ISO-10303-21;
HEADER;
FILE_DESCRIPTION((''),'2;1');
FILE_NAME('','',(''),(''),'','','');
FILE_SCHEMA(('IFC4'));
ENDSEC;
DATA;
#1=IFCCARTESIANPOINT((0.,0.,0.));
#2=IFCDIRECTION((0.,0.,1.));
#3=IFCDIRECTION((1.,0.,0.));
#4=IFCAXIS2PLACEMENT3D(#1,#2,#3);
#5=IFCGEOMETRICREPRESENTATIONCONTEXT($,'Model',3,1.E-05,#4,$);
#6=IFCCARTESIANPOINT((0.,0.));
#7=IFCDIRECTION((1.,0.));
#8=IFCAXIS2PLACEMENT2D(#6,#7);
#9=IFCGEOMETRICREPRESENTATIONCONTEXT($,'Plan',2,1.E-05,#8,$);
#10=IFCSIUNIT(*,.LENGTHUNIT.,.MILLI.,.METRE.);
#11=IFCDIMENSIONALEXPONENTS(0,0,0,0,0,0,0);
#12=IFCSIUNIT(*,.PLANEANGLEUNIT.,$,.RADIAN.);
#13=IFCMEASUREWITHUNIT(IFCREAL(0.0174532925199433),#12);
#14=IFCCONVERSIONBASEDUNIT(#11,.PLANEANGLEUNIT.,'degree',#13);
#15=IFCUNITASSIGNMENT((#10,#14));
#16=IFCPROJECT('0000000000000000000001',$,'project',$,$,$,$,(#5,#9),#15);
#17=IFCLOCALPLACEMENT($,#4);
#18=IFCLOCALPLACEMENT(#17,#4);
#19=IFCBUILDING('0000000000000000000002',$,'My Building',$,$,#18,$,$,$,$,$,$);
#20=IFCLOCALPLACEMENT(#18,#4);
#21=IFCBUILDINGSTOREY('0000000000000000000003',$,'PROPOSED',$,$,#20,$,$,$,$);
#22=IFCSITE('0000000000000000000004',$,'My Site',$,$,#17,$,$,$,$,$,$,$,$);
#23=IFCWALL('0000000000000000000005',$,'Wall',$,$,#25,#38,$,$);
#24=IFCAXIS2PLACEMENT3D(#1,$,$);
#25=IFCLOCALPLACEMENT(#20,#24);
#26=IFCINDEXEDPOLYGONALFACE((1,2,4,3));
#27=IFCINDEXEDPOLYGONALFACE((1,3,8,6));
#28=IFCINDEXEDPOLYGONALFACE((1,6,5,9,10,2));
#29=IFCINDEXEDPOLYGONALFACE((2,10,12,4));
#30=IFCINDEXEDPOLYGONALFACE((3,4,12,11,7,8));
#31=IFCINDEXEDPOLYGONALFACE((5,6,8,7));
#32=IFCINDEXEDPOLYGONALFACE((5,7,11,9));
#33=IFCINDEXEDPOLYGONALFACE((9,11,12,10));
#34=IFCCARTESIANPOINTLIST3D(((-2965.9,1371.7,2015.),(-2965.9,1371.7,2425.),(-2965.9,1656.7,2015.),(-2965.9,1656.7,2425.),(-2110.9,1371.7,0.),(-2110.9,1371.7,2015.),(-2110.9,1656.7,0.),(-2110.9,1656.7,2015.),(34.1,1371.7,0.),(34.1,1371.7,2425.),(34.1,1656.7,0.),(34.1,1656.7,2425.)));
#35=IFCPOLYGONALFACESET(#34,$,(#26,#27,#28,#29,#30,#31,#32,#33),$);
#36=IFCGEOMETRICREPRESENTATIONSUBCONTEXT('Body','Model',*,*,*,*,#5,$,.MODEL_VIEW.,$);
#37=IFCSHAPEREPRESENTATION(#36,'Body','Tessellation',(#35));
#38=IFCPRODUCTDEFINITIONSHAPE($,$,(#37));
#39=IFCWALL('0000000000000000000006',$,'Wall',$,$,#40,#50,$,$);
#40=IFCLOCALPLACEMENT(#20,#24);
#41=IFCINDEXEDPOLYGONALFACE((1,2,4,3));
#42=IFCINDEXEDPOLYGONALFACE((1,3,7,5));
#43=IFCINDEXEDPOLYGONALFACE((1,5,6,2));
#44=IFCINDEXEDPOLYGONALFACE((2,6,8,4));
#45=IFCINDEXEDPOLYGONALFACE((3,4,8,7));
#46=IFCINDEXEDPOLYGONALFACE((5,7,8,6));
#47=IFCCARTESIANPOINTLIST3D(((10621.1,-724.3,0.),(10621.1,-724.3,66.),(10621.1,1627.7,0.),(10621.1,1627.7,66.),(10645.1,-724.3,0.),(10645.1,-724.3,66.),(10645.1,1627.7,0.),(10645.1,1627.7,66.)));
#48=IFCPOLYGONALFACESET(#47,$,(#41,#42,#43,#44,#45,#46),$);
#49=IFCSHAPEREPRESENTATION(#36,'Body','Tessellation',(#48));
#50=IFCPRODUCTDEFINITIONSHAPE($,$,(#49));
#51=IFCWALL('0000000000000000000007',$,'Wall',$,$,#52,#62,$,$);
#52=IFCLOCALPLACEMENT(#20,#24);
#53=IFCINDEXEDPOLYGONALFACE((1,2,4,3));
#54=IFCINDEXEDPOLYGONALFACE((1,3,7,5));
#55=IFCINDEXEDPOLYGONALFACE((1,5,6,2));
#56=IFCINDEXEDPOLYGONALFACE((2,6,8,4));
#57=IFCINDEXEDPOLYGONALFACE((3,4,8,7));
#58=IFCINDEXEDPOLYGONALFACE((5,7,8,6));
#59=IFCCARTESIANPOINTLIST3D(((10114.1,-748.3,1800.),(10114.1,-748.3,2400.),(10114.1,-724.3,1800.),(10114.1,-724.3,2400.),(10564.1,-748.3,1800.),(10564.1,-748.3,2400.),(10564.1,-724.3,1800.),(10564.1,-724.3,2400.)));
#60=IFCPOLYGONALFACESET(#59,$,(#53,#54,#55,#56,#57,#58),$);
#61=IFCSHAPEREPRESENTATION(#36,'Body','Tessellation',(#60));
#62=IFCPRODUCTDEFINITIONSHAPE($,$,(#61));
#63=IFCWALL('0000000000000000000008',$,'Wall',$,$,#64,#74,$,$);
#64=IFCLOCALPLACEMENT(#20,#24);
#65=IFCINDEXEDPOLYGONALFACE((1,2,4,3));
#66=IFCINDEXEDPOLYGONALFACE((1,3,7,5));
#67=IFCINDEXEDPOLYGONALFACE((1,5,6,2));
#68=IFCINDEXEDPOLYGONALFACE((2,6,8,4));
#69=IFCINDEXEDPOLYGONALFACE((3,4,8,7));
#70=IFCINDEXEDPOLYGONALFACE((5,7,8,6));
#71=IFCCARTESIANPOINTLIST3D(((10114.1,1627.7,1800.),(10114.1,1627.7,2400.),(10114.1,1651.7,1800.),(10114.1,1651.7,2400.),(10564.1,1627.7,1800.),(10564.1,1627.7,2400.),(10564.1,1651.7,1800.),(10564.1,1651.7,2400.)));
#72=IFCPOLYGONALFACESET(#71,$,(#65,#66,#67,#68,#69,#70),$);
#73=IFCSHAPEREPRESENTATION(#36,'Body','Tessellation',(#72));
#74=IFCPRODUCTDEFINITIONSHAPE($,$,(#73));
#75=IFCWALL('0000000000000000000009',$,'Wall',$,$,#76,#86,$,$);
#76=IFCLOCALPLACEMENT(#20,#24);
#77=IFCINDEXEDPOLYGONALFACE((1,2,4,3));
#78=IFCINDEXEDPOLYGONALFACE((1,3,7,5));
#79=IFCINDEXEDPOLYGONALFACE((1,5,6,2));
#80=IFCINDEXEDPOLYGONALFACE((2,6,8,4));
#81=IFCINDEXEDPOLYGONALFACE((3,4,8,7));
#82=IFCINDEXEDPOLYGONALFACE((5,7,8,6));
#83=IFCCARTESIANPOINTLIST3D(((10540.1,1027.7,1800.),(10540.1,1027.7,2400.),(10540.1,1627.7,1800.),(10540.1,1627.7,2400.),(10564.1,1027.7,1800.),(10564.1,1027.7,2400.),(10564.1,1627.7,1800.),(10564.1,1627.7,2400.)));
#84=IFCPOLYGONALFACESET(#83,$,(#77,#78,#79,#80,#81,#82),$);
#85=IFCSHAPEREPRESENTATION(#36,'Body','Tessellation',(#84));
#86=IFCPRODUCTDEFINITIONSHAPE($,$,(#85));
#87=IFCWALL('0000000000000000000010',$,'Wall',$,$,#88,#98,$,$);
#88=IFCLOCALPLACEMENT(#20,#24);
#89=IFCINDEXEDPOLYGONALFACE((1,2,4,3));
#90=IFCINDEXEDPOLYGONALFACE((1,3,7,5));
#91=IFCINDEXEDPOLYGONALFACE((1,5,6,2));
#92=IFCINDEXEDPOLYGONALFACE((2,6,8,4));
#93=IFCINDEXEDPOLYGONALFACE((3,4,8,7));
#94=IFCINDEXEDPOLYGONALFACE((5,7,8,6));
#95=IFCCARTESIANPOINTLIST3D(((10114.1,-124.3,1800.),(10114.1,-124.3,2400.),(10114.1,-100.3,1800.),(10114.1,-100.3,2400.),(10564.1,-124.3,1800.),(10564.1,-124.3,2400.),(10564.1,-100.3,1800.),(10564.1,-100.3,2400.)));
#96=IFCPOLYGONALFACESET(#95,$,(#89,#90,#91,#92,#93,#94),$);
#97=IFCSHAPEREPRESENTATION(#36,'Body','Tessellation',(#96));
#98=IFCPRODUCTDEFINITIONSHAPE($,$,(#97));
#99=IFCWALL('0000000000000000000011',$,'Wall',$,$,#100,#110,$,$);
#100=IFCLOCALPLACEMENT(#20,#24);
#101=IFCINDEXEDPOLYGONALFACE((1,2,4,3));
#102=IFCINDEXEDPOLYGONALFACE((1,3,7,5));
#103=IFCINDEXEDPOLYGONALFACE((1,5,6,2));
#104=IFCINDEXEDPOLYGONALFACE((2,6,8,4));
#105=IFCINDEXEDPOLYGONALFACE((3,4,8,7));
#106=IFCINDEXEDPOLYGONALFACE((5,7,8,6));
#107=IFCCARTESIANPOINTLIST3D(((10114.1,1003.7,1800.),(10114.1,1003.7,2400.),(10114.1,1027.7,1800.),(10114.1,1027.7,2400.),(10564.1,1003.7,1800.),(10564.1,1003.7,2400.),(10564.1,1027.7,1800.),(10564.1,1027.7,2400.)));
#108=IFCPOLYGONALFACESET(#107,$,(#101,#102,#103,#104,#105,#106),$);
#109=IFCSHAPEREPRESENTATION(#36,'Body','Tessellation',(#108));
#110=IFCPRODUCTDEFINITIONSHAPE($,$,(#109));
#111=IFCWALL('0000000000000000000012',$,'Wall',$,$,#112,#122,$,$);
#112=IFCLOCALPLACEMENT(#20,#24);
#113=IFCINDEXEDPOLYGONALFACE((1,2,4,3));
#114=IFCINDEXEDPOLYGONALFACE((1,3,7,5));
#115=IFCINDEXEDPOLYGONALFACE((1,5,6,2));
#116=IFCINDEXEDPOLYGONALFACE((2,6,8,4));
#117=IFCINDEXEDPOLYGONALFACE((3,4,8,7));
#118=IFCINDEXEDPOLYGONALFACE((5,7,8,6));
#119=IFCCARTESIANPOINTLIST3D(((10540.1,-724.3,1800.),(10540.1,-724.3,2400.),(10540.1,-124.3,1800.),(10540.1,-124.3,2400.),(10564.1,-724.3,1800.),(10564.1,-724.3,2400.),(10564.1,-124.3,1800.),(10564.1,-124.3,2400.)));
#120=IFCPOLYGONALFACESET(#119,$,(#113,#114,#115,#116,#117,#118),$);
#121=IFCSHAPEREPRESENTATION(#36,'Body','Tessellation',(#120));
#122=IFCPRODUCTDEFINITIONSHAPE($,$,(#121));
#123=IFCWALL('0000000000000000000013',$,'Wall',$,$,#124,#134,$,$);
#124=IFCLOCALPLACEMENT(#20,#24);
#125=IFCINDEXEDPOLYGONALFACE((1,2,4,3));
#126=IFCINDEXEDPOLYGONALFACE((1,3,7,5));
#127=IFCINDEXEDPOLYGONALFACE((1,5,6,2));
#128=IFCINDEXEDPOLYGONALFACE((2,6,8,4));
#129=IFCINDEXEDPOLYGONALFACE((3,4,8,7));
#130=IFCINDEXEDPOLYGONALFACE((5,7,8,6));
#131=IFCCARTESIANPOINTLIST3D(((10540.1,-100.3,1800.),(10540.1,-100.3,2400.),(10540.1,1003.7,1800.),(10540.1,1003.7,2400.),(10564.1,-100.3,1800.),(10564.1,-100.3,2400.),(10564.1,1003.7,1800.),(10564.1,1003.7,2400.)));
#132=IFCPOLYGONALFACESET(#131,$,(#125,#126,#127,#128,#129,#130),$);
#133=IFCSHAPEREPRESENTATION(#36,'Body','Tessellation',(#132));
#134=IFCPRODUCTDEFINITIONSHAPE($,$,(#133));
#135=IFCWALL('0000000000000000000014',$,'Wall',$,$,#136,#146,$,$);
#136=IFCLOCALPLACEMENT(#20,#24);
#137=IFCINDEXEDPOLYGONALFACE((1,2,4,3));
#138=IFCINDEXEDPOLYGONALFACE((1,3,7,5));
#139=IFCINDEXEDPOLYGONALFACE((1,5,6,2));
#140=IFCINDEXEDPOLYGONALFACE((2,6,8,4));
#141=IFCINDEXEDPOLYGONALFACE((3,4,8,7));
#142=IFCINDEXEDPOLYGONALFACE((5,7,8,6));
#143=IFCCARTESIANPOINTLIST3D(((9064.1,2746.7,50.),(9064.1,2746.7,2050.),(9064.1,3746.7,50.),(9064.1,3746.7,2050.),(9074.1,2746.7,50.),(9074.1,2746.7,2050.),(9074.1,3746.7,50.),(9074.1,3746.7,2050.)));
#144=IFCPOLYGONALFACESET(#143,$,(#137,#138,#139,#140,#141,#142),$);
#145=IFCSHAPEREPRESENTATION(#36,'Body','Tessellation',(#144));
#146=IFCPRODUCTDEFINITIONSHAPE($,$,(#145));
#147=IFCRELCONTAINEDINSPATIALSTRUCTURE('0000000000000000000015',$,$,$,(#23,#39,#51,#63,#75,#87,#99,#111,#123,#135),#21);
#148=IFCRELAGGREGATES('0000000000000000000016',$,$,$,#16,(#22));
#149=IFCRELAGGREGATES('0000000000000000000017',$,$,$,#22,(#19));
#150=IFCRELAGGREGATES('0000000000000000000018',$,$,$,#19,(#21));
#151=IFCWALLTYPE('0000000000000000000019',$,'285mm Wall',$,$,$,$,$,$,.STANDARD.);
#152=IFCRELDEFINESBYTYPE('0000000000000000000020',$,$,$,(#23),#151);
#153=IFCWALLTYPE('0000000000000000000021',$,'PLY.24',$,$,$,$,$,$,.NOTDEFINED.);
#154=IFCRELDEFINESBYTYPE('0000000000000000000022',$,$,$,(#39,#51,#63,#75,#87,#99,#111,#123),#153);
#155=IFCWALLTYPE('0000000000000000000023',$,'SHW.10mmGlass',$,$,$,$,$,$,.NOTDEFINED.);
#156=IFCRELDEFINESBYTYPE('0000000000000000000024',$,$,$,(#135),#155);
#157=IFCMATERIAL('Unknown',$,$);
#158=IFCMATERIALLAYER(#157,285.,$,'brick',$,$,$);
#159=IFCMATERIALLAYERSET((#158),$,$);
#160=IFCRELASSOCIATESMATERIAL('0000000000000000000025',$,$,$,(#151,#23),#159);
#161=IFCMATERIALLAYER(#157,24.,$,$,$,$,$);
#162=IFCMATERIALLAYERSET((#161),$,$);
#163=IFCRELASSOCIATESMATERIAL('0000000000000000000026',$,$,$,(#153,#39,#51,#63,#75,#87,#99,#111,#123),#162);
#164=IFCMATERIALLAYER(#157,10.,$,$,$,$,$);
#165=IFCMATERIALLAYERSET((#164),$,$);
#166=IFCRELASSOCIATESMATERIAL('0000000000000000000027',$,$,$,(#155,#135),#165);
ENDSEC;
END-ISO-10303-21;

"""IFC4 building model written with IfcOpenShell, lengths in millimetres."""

from ifc_helpers import new_model, entity, si_unit, converted_unit, frame, origin_with_axes, origin_2d_with_axis, place, context, subcontext, project, spatial, line, indexed_curve, outline, extrude, source, transform, mapped, material, layer, layer_set, layer_usage, type_object, element, save


model = new_model("IFC4")

# Units and contexts
model_context = context("Model", 3, precision=1e-05, world=origin_with_axes())
plan_context = context("Plan", 2, precision=1e-05, world=origin_2d_with_axis())
body_context_1 = subcontext(model_context, "Body", "Model", "MODEL_VIEW")
ifc_project = project(units=[si_unit("LENGTHUNIT", "METRE", prefix="MILLI"), converted_unit("PLANEANGLEUNIT", "degree", entity("IfcReal", 0.0174532925199433), si_unit("PLANEANGLEUNIT", "RADIAN"), dimensions=[0, 0, 0, 0, 0, 0, 0])], contexts=[model_context, plan_context])

# Site, building, storey
site_placement = place(None, origin_with_axes())
site = spatial("IfcSite", under=ifc_project, at=site_placement, Name="My Site")
building_placement = place(site_placement, origin_with_axes())
building = spatial("IfcBuilding", under=site, at=building_placement, Name="My Building")
storey_placement = place(building_placement, origin_with_axes())
storey = spatial("IfcBuildingStorey", under=building, at=storey_placement, Name="PROPOSED")

# Shared definitions
ifc_material = material(Name="Unknown")

# Shared definitions
ifc_layer_1 = layer(ifc_material, 285.0, Name="brick")
ifc_layer_set_1 = layer_set([ifc_layer_1])
wall_type_1 = type_object("IfcWallType", Name="285mm Wall", PredefinedType="STANDARD", material=ifc_layer_set_1)

# Wall, opening
ifc_layer_usage_1 = layer_usage(ifc_layer_set_1, "AXIS2", "POSITIVE", 0.0)
wall_1_placement = place(storey_placement, frame((-2965.9, 1371.7, 0.0), z_axis=(0.0, 0.0, 1.0), x_axis=(1.0, 0.0, 0.0)))
wall_1 = element("IfcWall", 1, at=wall_1_placement, inside=storey, type_object=wall_type_1, material=ifc_layer_usage_1, Name="Wall", context=body_context_1, shape_type="SweptSolid", body=[
    extrude(outline(indexed_curve([(0.0, 0.0), (0.0, 285.0), (3000.0, 285.0), (3000.0, 0.0), (0.0, 0.0)], self_intersect=False)), origin_with_axes(), (0.0, 0.0, 1.0), 2425.0),
])
shared_shape_1 = source(origin_with_axes(), body_context_1, "Body", "SweptSolid", [
    extrude(outline(indexed_curve([(0.0, 0.0), (855.0, 0.0), (855.0, 2015.0), (0.0, 2015.0)], segments=[line(1, 2, 3, 4, 1)])), frame((0.0, -600.0, 0.0), z_axis=(0.0, -1.0, 0.0), x_axis=(1.0, 0.0, 0.0)), (0.0, 0.0, -1.0), 1200.0),
])
opening_1_placement = place(wall_1_placement, frame((0.0, 0.0, 0.0), z_axis=(0.0, 0.0, 1.0), x_axis=(1.0, 0.0, 0.0)))
element("IfcOpeningElement", 2, at=opening_1_placement, cuts=wall_1, PredefinedType="OPENING", context=body_context_1, shape_type="MappedRepresentation", body=[
    mapped(shared_shape_1, transform((0.0, 0.0, 0.0), x_axis=(1.0, 0.0, 0.0), y_axis=(0.0, 1.0, 0.0), z_axis=(0.0, 0.0, 1.0), scale=1.0)),
])

# Walls
ifc_layer_2 = layer(ifc_material, 24.0)
ifc_layer_set_2 = layer_set([ifc_layer_2])
ifc_layer_usage_2 = layer_usage(ifc_layer_set_2, "AXIS2", "POSITIVE", 0.0)
wall_type_2 = type_object("IfcWallType", Name="PLY.24", PredefinedType="NOTDEFINED", material=ifc_layer_set_2)
wall_2_placement = place(storey_placement, frame((10621.1, 1627.7, 0.0), z_axis=(0.0, 0.0, 1.0), x_axis=(0.0, -1.0, 0.0)))
element("IfcWall", 3, at=wall_2_placement, inside=storey, type_object=wall_type_2, material=ifc_layer_usage_2, Name="Wall", context=body_context_1, shape_type="SweptSolid", body=[
    extrude(outline(indexed_curve([(0.0, 0.0), (0.0, 24.0), (2352.0, 24.0), (2352.0, 0.0), (0.0, 0.0)], self_intersect=False)), origin_with_axes(), (0.0, 0.0, 1.0), 66.0),
])
ifc_layer_usage_3 = layer_usage(ifc_layer_set_2, "AXIS2", "POSITIVE", 0.0)
wall_3_placement = place(storey_placement, frame((10564.1, -724.3, 1800.0), z_axis=(0.0, 0.0, 1.0), x_axis=(-1.0, 0.0, 0.0)))
element("IfcWall", 4, at=wall_3_placement, inside=storey, type_object=wall_type_2, material=ifc_layer_usage_3, Name="Wall", context=body_context_1, shape_type="SweptSolid", body=[
    extrude(outline(indexed_curve([(0.0, 0.0), (0.0, 24.0), (450.0, 24.0), (450.0, 0.0), (0.0, 0.0)], self_intersect=False)), origin_with_axes(), (0.0, 0.0, 1.0), 600.0),
])
ifc_layer_usage_4 = layer_usage(ifc_layer_set_2, "AXIS2", "POSITIVE", 0.0)
wall_4_placement = place(storey_placement, frame((10564.1, 1651.7, 1800.0), z_axis=(0.0, 0.0, 1.0), x_axis=(-1.0, 0.0, 0.0)))
element("IfcWall", 5, at=wall_4_placement, inside=storey, type_object=wall_type_2, material=ifc_layer_usage_4, Name="Wall", context=body_context_1, shape_type="SweptSolid", body=[
    extrude(outline(indexed_curve([(0.0, 0.0), (0.0, 24.0), (450.0, 24.0), (450.0, 0.0), (0.0, 0.0)], self_intersect=False)), origin_with_axes(), (0.0, 0.0, 1.0), 600.0),
])
ifc_layer_usage_5 = layer_usage(ifc_layer_set_2, "AXIS2", "POSITIVE", 0.0)
wall_5_placement = place(storey_placement, frame((10564.1, 1027.7, 1800.0), z_axis=(0.0, 0.0, 1.0), x_axis=(0.0, 1.0, 0.0)))
element("IfcWall", 6, at=wall_5_placement, inside=storey, type_object=wall_type_2, material=ifc_layer_usage_5, Name="Wall", context=body_context_1, shape_type="SweptSolid", body=[
    extrude(outline(indexed_curve([(0.0, 0.0), (0.0, 24.0), (600.0, 24.0), (600.0, 0.0), (0.0, 0.0)], self_intersect=False)), origin_with_axes(), (0.0, 0.0, 1.0), 600.0),
])
ifc_layer_usage_6 = layer_usage(ifc_layer_set_2, "AXIS2", "POSITIVE", 0.0)
wall_6_placement = place(storey_placement, frame((10564.1, -100.3, 1800.0), z_axis=(0.0, 0.0, 1.0), x_axis=(-1.0, 0.0, 0.0)))
element("IfcWall", 7, at=wall_6_placement, inside=storey, type_object=wall_type_2, material=ifc_layer_usage_6, Name="Wall", context=body_context_1, shape_type="SweptSolid", body=[
    extrude(outline(indexed_curve([(0.0, 0.0), (0.0, 24.0), (450.0, 24.0), (450.0, 0.0), (0.0, 0.0)], self_intersect=False)), origin_with_axes(), (0.0, 0.0, 1.0), 600.0),
])
ifc_layer_usage_7 = layer_usage(ifc_layer_set_2, "AXIS2", "POSITIVE", 0.0)
wall_7_placement = place(storey_placement, frame((10564.1, 1027.7, 1800.0), z_axis=(0.0, 0.0, 1.0), x_axis=(-1.0, 0.0, 0.0)))
element("IfcWall", 8, at=wall_7_placement, inside=storey, type_object=wall_type_2, material=ifc_layer_usage_7, Name="Wall", context=body_context_1, shape_type="SweptSolid", body=[
    extrude(outline(indexed_curve([(0.0, 0.0), (0.0, 24.0), (450.0, 24.0), (450.0, 0.0), (0.0, 0.0)], self_intersect=False)), origin_with_axes(), (0.0, 0.0, 1.0), 600.0),
])
ifc_layer_usage_8 = layer_usage(ifc_layer_set_2, "AXIS2", "POSITIVE", 0.0)
wall_8_placement = place(storey_placement, frame((10564.1, -724.3, 1800.0), z_axis=(0.0, 0.0, 1.0), x_axis=(0.0, 1.0, 0.0)))
element("IfcWall", 9, at=wall_8_placement, inside=storey, type_object=wall_type_2, material=ifc_layer_usage_8, Name="Wall", context=body_context_1, shape_type="SweptSolid", body=[
    extrude(outline(indexed_curve([(0.0, 0.0), (0.0, 24.0), (600.0, 24.0), (600.0, 0.0), (0.0, 0.0)], self_intersect=False)), origin_with_axes(), (0.0, 0.0, 1.0), 600.0),
])
ifc_layer_usage_9 = layer_usage(ifc_layer_set_2, "AXIS2", "POSITIVE", 0.0)
wall_9_placement = place(storey_placement, frame((10564.1, -100.3, 1800.0), z_axis=(0.0, 0.0, 1.0), x_axis=(0.0, 1.0, 0.0)))
element("IfcWall", 10, at=wall_9_placement, inside=storey, type_object=wall_type_2, material=ifc_layer_usage_9, Name="Wall", context=body_context_1, shape_type="SweptSolid", body=[
    extrude(outline(indexed_curve([(0.0, 0.0), (0.0, 24.0), (1104.0, 24.0), (1104.0, 0.0), (0.0, 0.0)], self_intersect=False)), origin_with_axes(), (0.0, 0.0, 1.0), 600.0),
])
ifc_layer_3 = layer(ifc_material, 10.0)
ifc_layer_set_3 = layer_set([ifc_layer_3])
ifc_layer_usage_10 = layer_usage(ifc_layer_set_3, "AXIS2", "POSITIVE", 0.0)
wall_type_3 = type_object("IfcWallType", Name="SHW.10mmGlass", PredefinedType="NOTDEFINED", material=ifc_layer_set_3)
wall_10_placement = place(storey_placement, frame((9074.1, 2746.7, 50.0), z_axis=(0.0, 0.0, 1.0), x_axis=(0.0, 1.0, 0.0)))
element("IfcWall", 11, at=wall_10_placement, inside=storey, type_object=wall_type_3, material=ifc_layer_usage_10, Name="Wall", context=body_context_1, shape_type="SweptSolid", body=[
    extrude(outline(indexed_curve([(0.0, 0.0), (0.0, 10.0), (1000.0, 10.0), (1000.0, 0.0), (0.0, 0.0)], self_intersect=False)), origin_with_axes(), (0.0, 0.0, 1.0), 2000.0),
])

save(model, "model.ifc")
